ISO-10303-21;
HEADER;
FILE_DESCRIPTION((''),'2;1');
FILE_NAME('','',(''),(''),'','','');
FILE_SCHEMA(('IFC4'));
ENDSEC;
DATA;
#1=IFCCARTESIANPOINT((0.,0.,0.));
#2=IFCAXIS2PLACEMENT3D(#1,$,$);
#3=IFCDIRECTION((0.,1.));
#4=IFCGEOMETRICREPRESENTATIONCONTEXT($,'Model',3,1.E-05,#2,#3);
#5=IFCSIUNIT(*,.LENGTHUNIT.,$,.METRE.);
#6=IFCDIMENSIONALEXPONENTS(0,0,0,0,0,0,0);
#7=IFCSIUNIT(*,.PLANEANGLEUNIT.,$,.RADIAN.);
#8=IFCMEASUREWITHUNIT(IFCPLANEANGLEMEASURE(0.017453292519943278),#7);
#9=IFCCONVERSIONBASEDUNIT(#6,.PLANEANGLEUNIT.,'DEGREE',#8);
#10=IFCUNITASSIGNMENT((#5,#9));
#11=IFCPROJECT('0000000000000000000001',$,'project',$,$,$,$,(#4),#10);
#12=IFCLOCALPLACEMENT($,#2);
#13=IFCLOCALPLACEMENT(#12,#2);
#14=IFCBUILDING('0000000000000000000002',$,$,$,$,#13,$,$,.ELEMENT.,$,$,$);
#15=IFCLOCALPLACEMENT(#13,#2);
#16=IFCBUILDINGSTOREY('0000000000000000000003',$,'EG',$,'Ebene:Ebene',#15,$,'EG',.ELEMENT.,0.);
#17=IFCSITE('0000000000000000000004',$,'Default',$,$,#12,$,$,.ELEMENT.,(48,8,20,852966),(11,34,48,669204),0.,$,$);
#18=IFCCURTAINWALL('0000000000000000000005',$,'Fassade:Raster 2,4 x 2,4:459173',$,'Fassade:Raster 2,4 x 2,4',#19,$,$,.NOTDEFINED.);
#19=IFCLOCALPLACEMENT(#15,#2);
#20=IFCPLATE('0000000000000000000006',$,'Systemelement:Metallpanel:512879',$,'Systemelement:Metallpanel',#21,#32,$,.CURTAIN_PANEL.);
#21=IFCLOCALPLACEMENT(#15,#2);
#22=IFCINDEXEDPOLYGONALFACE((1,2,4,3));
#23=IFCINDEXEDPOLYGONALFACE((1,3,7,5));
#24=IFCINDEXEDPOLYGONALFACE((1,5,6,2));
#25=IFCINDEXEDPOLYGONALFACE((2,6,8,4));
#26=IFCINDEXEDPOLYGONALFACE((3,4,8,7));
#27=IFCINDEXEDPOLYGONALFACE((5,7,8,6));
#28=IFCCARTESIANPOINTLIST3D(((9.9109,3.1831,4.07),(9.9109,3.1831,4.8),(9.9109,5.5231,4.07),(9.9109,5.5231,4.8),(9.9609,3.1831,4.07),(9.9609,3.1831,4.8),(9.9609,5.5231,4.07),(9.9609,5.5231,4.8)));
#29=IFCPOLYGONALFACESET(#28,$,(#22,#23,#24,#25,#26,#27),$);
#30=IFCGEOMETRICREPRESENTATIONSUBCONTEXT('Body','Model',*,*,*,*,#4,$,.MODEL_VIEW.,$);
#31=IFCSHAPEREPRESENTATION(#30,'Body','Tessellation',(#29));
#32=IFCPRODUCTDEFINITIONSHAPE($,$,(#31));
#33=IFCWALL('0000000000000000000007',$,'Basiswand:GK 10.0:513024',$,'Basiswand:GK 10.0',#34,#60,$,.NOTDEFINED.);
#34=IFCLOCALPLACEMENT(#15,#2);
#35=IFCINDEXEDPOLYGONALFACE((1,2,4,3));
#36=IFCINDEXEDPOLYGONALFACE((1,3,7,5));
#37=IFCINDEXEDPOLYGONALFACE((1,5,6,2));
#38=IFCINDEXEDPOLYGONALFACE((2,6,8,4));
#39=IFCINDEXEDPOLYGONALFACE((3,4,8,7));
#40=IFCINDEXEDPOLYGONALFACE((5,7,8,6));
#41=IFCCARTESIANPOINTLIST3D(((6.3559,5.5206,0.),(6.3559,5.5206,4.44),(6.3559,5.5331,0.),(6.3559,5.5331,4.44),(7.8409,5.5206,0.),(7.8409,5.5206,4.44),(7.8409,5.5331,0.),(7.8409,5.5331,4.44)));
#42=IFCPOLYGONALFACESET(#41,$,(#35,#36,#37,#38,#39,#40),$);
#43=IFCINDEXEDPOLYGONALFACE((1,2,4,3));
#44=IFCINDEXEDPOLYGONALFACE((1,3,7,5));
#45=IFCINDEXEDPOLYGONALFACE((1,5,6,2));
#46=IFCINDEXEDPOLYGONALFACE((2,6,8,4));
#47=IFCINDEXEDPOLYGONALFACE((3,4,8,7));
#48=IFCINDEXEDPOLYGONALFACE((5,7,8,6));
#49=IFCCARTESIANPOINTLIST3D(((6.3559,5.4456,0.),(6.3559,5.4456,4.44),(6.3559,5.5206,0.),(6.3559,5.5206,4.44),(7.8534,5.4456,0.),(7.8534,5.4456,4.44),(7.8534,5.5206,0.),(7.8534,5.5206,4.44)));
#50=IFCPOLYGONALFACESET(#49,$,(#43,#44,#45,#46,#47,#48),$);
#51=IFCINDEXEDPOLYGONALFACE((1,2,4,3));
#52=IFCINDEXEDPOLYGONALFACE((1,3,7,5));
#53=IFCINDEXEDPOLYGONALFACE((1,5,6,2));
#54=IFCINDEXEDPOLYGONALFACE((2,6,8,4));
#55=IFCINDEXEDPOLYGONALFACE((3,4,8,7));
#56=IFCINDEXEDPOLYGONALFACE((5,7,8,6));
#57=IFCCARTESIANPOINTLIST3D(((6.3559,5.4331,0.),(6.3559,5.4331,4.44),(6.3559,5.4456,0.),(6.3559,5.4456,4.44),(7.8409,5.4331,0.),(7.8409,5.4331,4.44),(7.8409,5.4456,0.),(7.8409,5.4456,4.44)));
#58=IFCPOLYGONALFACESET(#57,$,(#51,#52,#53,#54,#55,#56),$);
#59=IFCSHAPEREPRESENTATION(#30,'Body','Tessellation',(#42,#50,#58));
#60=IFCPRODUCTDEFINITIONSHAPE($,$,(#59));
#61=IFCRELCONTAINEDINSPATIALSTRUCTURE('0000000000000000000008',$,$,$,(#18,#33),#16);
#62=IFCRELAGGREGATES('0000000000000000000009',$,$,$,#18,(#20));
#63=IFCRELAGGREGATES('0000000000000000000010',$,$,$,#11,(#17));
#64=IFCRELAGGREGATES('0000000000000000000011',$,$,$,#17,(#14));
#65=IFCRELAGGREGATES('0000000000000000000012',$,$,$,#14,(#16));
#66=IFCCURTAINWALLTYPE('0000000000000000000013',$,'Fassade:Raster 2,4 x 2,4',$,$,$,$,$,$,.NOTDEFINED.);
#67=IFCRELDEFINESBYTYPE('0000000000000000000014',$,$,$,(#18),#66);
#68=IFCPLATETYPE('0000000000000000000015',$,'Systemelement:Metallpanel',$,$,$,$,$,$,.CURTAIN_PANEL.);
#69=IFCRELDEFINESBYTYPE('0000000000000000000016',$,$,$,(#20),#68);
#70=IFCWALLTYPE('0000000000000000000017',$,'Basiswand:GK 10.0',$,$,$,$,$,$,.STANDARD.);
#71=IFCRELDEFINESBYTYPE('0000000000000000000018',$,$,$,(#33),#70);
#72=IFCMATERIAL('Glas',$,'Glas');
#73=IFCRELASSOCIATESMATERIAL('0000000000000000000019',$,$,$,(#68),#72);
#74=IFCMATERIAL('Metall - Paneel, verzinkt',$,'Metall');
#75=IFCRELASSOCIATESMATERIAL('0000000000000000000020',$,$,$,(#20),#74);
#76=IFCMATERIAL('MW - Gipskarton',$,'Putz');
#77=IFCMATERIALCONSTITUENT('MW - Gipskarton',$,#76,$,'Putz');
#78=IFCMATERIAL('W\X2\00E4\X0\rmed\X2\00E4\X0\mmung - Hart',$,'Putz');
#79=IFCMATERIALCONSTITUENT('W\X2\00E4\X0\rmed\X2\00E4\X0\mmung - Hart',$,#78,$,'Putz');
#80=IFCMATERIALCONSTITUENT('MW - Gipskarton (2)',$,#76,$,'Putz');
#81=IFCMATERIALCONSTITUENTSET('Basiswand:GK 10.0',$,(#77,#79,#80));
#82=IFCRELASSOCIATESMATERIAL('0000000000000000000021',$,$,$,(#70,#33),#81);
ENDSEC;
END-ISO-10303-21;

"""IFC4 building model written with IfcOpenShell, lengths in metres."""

from ifc_helpers import new_model, entity, si_unit, converted_unit, direction, frame, origin, place, context, subcontext, project, spatial, indexed_curve, outline, extrude, source, transform, mapped, material, constituent, constituent_set, type_object, type_shapes, element, aggregate, save


model = new_model("IFC4")

# Units and contexts
model_context = context("Model", 3, precision=1e-05, world=origin(), true_north=direction((0.0, 1.0)))
body_context = subcontext(model_context, "Body", "Model", "MODEL_VIEW")
ifc_project = project(units=[si_unit("LENGTHUNIT", "METRE"), converted_unit("PLANEANGLEUNIT", "DEGREE", entity("IfcPlaneAngleMeasure", 0.017453292519943278), si_unit("PLANEANGLEUNIT", "RADIAN"), dimensions=[0, 0, 0, 0, 0, 0, 0])], contexts=[model_context])

# Site, building, storey
site_placement = place(None, origin())
site = spatial("IfcSite", under=ifc_project, at=site_placement, Name="Default", CompositionType="ELEMENT", RefLatitude=(48, 8, 20, 852966), RefLongitude=(11, 34, 48, 669204), RefElevation=0.0)
building_placement = place(site_placement, origin())
building = spatial("IfcBuilding", under=site, at=building_placement, CompositionType="ELEMENT")
storey_placement = place(building_placement, origin())
storey = spatial("IfcBuildingStorey", under=building, at=storey_placement, Name="EG", ObjectType="Ebene:Ebene", LongName="EG", CompositionType="ELEMENT", Elevation=0.0)

# Curtain wall
curtain_wall_type = type_object("IfcCurtainWallType", Name="Fassade:Raster 2,4 x 2,4", PredefinedType="NOTDEFINED")
curtain_wall_placement = place(storey_placement, origin())
curtain_wall = element("IfcCurtainWall", 1, at=curtain_wall_placement, inside=storey, type_object=curtain_wall_type, Name="Fassade:Raster 2,4 x 2,4:459173", ObjectType="Fassade:Raster 2,4 x 2,4", PredefinedType="NOTDEFINED")

# Shared definitions
ifc_material_1 = material(Name="Wärmedämmung - Hart", Category="Putz")

# Plate
ifc_material_2 = material(Name="Glas", Category="Glas")
ifc_material_3 = material(Name="Metall - Paneel, verzinkt", Category="Metall")
plate_type_1 = type_object("IfcPlateType", Name="Systemelement:Metallpanel", PredefinedType="CURTAIN_PANEL", material=ifc_material_2)
shared_shape_1 = source(origin(), body_context, "Body", "SweptSolid", [
    extrude(outline(indexed_curve([(-0.025, -1.17), (0.025, -1.17), (0.025, 1.17), (-0.025, 1.17), (-0.025, -1.17)], self_intersect=False)), frame((0.0, 0.0, 0.0), z_axis=(0.0, 0.0, 1.0), x_axis=(0.0, 1.0, 0.0)), (0.0, 0.0, 1.0), 0.73),
])
type_shapes(plate_type_1, [shared_shape_1])
plate_1_placement = place(curtain_wall_placement, frame((9.9359, 4.3531, 4.07), z_axis=(0.0, 0.0, 1.0), x_axis=(0.0, 1.0, 0.0)))
plate_1 = element("IfcPlate", 2, at=plate_1_placement, type_object=plate_type_1, material=ifc_material_3, Name="Systemelement:Metallpanel:512879", ObjectType="Systemelement:Metallpanel", PredefinedType="CURTAIN_PANEL", context=body_context, shape_type="MappedRepresentation", body=[
    mapped(shared_shape_1, transform((0.0, 0.0, 0.0), scale=1.0)),
])
aggregate(curtain_wall, [plate_1])

# Wall
ifc_material_4 = material(Name="MW - Gipskarton", Category="Putz")
ifc_constituent_1 = constituent(ifc_material_4, Name="MW - Gipskarton", Category="Putz")
ifc_constituent_2 = constituent(ifc_material_1, Name="Wärmedämmung - Hart", Category="Putz")
ifc_constituent_3 = constituent(ifc_material_4, Name="MW - Gipskarton (2)", Category="Putz")
ifc_constituent_set_1 = constituent_set(constituents=[ifc_constituent_1, ifc_constituent_2, ifc_constituent_3], Name="Basiswand:GK 10.0")
wall_type = type_object("IfcWallType", Name="Basiswand:GK 10.0", PredefinedType="STANDARD", material=ifc_constituent_set_1)
wall_1_placement = place(storey_placement, frame((7.8409, 5.4831, 0.0), z_axis=(0.0, 0.0, 1.0), x_axis=(-1.0, 0.0, 0.0)))
element("IfcWall", 3, at=wall_1_placement, inside=storey, type_object=wall_type, material=ifc_constituent_set_1, Name="Basiswand:GK 10.0:513024", ObjectType="Basiswand:GK 10.0", PredefinedType="NOTDEFINED", context=body_context, shape_type="SweptSolid", body=[
    extrude(outline(indexed_curve([(-0.0063, -0.7425), (0.0062, -0.7425), (0.0063, 0.7425), (-0.0062, 0.7425), (-0.0063, -0.7425)], self_intersect=False)), frame((0.7425, -0.0437, 0.0), z_axis=(0.0, 0.0, 1.0), x_axis=(0.0, 1.0, 0.0)), (0.0, 0.0, 1.0), 4.44),
    extrude(outline(indexed_curve([(-0.7488, -0.0375), (0.7488, -0.0375), (0.7488, 0.0375), (-0.7488, 0.0375), (-0.7488, -0.0375)], self_intersect=False)), frame((0.7363, 0.0, 0.0)), (0.0, 0.0, 1.0), 4.44),
    extrude(outline(indexed_curve([(-0.0063, -0.7425), (0.0062, -0.7425), (0.0063, 0.7425), (-0.0062, 0.7425), (-0.0063, -0.7425)], self_intersect=False)), frame((0.7425, 0.0438, 0.0), z_axis=(0.0, 0.0, 1.0), x_axis=(0.0, -1.0, 0.0)), (0.0, 0.0, 1.0), 4.44),
])

save(model, "model.ifc")
